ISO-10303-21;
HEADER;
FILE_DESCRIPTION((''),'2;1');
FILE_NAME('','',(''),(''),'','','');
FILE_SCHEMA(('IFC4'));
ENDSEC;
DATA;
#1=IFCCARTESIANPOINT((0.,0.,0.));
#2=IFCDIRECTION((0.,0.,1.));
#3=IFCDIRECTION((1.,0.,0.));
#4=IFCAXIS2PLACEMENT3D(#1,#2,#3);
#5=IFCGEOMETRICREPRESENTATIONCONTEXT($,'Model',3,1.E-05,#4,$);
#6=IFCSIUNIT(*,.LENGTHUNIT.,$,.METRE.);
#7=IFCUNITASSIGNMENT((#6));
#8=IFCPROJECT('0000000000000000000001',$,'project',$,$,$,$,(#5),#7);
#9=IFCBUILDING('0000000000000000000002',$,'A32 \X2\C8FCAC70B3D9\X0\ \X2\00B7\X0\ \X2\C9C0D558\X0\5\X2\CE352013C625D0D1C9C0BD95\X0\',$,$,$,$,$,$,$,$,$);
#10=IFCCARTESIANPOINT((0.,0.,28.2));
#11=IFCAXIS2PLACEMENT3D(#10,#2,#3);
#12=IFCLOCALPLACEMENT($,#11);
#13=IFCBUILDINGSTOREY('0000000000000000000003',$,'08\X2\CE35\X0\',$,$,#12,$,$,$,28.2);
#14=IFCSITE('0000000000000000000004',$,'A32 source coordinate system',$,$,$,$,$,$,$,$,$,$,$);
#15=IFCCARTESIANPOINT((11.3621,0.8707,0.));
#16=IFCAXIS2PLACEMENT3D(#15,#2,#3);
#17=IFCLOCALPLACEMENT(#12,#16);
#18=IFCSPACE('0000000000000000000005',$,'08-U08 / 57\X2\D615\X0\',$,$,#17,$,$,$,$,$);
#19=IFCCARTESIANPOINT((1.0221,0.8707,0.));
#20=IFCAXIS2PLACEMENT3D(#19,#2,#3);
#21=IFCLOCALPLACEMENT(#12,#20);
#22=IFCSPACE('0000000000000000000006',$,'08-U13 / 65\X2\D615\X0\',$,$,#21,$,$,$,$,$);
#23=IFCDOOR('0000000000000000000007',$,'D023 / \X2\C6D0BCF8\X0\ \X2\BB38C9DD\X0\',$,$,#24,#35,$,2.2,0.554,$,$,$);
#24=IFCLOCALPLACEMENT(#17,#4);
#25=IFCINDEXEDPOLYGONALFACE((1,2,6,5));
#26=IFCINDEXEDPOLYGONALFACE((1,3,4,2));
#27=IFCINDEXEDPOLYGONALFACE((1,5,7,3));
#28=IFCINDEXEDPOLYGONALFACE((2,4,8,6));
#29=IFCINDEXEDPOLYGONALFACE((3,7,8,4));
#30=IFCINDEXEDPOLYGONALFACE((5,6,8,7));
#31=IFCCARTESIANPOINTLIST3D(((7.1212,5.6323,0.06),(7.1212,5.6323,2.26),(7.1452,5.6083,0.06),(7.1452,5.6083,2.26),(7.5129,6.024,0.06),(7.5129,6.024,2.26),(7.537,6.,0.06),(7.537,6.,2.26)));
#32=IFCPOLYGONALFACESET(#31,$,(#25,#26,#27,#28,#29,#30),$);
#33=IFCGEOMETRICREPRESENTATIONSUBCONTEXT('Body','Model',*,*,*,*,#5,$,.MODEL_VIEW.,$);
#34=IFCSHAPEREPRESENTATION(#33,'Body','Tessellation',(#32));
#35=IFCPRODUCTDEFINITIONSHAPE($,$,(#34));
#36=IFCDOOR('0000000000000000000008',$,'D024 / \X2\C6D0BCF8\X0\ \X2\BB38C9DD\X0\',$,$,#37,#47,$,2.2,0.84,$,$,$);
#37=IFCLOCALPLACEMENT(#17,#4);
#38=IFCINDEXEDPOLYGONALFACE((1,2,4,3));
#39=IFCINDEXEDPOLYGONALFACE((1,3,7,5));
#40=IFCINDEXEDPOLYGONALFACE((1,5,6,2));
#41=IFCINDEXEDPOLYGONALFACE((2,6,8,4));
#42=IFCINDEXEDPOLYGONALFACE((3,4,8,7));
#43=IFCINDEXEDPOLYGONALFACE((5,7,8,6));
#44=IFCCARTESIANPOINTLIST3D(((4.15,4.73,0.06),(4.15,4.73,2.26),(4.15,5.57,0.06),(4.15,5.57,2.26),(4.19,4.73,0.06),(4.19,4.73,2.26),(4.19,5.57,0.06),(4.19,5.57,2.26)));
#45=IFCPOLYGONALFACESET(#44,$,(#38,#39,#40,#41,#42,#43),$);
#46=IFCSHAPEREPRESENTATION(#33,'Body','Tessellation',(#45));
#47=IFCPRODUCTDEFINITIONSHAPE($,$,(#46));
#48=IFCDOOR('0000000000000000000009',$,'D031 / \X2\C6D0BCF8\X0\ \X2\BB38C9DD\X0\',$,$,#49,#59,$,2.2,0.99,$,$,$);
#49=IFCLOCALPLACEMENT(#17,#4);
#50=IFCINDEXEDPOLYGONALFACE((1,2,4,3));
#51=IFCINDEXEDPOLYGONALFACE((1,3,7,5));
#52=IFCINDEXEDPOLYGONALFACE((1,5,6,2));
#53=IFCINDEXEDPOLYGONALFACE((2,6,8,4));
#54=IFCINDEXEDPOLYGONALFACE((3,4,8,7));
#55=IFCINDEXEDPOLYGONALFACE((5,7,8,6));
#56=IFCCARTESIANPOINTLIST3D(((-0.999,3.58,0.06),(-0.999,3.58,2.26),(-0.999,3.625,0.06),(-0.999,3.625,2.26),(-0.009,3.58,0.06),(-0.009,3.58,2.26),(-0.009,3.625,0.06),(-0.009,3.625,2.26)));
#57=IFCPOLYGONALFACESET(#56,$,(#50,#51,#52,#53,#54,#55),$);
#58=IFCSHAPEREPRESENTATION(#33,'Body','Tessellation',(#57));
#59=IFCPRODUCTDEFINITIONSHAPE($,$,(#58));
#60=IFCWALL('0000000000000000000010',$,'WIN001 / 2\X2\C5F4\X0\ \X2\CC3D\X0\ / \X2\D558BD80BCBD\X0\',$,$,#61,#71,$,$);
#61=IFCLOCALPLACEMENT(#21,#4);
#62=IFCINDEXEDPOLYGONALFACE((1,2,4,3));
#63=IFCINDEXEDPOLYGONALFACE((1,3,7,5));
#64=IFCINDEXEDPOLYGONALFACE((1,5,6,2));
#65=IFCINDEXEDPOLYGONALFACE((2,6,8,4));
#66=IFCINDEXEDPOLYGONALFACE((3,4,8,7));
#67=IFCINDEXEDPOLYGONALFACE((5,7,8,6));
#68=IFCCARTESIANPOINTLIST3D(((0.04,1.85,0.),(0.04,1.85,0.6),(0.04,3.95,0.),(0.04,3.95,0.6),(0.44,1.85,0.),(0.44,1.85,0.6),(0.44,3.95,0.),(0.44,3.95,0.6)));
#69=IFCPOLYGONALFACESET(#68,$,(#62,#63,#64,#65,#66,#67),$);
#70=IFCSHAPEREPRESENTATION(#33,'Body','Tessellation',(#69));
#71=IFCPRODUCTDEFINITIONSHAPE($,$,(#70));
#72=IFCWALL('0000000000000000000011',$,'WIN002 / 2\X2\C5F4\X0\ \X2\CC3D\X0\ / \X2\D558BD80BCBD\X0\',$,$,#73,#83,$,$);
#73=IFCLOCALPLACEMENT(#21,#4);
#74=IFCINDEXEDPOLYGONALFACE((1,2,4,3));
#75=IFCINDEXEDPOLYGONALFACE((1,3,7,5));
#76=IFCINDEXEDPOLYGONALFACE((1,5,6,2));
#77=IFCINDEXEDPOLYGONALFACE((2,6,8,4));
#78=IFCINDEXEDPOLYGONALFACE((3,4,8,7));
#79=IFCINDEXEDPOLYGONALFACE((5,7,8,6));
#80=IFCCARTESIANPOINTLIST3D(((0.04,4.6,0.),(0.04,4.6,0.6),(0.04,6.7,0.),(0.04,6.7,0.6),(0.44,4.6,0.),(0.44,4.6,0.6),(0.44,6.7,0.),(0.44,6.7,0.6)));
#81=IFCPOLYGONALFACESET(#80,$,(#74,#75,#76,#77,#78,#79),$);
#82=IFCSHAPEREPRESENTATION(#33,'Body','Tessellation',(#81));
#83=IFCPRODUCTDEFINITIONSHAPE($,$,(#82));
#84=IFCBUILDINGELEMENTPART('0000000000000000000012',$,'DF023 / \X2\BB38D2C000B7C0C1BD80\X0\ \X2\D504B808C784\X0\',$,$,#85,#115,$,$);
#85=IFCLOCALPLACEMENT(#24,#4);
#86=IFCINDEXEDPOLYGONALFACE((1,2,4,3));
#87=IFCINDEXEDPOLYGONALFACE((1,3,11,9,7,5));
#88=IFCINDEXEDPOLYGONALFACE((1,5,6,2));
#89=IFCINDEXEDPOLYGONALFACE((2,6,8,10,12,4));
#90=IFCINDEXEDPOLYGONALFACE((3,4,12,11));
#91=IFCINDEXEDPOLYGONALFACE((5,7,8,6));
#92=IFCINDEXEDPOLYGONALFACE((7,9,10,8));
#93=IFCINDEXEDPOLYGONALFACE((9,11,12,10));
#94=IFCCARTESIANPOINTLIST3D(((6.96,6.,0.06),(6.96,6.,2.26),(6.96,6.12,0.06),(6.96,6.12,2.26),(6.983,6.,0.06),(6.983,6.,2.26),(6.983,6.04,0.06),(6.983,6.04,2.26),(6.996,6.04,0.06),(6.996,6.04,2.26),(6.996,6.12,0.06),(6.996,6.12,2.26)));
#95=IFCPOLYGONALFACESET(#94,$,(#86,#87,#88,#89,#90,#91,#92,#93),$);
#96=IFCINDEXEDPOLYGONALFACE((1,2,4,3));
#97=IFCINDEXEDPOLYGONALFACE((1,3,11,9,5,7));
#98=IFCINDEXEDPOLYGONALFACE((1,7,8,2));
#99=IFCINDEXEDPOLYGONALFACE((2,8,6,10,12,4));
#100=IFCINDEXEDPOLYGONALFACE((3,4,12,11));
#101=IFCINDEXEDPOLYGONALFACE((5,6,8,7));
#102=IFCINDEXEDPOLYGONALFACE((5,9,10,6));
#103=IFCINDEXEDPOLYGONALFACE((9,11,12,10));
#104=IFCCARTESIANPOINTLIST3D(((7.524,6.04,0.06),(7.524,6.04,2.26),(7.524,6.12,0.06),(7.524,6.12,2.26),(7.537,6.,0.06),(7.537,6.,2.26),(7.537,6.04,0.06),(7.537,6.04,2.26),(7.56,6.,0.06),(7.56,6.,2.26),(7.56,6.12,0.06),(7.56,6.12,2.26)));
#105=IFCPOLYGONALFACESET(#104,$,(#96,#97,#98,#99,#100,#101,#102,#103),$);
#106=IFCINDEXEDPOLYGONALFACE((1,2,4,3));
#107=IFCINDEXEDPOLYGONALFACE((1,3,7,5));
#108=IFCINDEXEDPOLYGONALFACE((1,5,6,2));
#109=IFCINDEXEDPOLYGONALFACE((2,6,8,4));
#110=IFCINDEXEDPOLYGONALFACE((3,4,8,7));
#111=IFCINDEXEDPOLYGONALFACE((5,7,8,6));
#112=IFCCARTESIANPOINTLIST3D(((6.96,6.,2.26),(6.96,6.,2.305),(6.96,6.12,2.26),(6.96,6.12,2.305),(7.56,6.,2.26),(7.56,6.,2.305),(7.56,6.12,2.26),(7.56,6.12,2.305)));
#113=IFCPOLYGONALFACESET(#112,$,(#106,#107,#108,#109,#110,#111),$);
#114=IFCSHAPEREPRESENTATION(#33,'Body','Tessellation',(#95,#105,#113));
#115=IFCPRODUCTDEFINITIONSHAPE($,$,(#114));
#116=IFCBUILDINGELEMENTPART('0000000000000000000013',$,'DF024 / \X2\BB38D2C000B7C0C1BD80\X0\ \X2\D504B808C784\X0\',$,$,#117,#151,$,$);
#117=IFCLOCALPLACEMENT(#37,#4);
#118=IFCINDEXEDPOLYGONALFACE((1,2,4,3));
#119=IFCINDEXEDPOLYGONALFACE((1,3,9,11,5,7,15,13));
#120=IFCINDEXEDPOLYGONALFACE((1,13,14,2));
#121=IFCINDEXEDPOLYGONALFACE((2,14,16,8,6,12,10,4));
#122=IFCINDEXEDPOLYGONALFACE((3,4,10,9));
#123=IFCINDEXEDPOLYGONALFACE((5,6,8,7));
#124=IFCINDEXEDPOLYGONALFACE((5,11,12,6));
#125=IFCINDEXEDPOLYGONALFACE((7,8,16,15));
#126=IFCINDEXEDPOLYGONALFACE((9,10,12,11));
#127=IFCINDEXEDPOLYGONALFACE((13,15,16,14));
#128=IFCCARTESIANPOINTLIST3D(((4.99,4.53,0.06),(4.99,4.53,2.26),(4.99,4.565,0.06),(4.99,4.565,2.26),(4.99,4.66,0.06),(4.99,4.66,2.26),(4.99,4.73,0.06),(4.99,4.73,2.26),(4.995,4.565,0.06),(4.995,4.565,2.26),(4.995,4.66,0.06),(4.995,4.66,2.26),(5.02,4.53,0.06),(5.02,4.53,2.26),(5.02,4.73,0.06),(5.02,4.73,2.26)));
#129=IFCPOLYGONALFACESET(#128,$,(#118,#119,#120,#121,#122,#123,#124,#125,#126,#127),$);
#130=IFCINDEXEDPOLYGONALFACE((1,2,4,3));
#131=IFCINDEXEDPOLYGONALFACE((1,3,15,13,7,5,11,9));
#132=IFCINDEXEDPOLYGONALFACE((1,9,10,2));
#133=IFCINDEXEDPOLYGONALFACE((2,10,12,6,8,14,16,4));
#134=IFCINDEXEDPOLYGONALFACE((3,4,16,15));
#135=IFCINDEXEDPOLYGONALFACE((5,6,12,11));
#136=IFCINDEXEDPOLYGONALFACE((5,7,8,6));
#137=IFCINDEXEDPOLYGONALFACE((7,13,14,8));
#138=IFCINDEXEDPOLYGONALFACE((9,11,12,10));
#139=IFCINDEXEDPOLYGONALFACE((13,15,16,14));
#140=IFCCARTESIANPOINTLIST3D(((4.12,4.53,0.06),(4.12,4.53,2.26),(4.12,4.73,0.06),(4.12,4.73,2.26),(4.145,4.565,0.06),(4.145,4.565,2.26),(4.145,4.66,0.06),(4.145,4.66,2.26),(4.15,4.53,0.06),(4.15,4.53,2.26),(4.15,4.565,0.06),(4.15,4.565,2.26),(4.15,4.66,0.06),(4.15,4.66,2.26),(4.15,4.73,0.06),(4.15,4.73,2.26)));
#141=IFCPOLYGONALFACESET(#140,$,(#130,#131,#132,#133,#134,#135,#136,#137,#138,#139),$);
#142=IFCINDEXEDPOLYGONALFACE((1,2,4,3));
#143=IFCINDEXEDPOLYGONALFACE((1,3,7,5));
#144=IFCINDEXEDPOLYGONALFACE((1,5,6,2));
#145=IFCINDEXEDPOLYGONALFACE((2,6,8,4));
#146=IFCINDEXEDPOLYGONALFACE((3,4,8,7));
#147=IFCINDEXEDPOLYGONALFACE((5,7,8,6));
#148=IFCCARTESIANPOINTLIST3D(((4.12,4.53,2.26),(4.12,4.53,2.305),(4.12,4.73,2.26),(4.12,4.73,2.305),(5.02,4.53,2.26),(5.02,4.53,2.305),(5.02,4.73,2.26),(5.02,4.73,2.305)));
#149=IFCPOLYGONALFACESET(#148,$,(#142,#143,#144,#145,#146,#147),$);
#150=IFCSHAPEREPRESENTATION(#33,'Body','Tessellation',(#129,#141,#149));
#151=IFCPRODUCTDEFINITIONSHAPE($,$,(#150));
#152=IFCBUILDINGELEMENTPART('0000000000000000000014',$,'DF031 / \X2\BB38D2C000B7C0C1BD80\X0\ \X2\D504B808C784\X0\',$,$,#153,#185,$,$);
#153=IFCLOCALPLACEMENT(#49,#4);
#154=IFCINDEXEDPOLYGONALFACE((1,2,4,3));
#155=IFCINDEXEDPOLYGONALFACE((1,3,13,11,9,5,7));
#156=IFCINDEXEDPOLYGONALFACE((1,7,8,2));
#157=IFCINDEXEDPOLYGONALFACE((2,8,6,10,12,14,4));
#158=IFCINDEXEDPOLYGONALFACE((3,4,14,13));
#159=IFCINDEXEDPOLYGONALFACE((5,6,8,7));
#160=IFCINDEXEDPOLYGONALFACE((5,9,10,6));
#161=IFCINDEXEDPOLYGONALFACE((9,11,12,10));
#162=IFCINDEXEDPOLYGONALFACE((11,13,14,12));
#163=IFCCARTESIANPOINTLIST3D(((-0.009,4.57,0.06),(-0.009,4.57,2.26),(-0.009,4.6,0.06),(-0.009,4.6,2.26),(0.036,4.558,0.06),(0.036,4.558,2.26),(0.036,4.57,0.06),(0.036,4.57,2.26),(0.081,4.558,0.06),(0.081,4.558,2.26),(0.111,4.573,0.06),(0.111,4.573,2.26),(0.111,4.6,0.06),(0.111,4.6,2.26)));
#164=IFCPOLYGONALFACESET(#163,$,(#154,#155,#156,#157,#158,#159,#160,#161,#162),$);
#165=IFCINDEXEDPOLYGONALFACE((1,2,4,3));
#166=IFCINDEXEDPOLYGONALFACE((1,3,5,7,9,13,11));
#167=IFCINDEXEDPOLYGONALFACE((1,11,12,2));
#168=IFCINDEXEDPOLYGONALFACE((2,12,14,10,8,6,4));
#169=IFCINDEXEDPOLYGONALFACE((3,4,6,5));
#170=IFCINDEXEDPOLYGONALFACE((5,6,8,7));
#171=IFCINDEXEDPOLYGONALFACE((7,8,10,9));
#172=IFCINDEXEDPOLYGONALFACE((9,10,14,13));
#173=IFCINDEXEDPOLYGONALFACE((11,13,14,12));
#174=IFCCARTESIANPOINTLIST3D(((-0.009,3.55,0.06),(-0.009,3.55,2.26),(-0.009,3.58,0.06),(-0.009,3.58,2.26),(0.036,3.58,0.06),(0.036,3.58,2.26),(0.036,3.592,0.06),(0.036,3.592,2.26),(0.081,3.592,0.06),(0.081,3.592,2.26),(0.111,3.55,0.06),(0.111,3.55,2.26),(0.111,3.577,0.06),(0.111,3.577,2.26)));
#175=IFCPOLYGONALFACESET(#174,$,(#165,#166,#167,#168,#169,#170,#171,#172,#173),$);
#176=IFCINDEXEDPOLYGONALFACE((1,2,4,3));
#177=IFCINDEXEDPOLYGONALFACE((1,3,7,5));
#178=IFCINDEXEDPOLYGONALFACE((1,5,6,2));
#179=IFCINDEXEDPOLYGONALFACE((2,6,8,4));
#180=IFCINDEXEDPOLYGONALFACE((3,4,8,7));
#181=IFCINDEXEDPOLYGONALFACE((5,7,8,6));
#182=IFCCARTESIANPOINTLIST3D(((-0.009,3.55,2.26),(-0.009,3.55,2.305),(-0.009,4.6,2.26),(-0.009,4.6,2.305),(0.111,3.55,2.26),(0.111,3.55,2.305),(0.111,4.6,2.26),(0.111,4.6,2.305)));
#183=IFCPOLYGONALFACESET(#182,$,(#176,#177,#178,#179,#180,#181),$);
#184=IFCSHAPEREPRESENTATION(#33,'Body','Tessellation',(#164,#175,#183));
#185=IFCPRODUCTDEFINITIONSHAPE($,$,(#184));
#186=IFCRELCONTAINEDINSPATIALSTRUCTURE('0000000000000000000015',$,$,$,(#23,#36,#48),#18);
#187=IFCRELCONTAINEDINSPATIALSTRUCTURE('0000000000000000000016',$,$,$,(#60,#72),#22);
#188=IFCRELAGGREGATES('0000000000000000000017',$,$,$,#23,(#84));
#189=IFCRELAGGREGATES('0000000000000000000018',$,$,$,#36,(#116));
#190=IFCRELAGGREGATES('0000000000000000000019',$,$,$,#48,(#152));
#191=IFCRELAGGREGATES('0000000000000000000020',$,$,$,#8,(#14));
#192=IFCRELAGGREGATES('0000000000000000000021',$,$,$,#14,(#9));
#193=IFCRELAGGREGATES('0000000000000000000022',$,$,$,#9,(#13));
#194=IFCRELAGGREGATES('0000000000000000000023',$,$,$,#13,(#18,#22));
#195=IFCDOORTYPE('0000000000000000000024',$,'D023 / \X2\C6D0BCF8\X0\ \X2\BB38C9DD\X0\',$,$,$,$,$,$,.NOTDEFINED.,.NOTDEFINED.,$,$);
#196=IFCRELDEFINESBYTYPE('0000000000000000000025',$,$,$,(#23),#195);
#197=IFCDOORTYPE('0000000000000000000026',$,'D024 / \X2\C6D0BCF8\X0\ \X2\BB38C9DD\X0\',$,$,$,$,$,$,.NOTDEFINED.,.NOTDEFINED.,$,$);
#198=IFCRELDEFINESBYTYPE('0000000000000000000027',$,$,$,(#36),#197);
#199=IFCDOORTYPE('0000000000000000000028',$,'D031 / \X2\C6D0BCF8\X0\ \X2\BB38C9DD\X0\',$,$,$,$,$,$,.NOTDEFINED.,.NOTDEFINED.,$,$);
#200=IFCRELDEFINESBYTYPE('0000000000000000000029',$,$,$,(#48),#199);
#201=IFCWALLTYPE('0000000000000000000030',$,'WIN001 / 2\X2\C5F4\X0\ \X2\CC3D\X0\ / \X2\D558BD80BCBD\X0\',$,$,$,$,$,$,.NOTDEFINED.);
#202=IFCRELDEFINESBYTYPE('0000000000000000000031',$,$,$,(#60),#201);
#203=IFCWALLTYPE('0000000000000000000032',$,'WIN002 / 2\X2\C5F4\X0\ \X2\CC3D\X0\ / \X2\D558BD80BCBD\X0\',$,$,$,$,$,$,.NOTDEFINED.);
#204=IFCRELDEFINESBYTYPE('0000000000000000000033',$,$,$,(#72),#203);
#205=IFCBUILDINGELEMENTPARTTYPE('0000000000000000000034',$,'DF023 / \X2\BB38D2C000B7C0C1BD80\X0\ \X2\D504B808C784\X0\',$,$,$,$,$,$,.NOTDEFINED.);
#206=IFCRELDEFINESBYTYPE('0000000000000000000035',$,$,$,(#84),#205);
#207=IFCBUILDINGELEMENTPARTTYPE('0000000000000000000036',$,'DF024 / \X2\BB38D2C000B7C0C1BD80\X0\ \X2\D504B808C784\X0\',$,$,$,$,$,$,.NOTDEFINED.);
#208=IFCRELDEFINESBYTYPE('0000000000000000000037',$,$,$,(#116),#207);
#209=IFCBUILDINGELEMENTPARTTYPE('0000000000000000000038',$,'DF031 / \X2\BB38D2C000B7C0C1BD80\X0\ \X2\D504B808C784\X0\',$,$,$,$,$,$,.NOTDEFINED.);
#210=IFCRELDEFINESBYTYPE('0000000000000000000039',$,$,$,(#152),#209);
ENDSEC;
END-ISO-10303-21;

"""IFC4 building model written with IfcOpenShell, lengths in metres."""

from ifc_helpers import new_model, si_unit, frame, origin, origin_with_axes, place, context, subcontext, project, spatial, polyline, outline, extrude, source, transform, mapped, type_object, type_shapes, element, aggregate, save


model = new_model("IFC4")

# Units and contexts
model_context = context("Model", 3, precision=1e-05, world=origin_with_axes())
body_context = subcontext(model_context, "Body", "Model", "MODEL_VIEW")
ifc_project = project(units=[si_unit("LENGTHUNIT", "METRE")], contexts=[model_context])

# Site, building, storey, space
site = spatial("IfcSite", under=ifc_project, Name="A32 source coordinate system")
building = spatial("IfcBuilding", under=site, Name="A32 주거동 · 지하5층–옥탑지붕")
storey_placement = place(None, frame((0.0, 0.0, 28.2), z_axis=(0.0, 0.0, 1.0), x_axis=(1.0, 0.0, 0.0)))
storey = spatial("IfcBuildingStorey", under=building, at=storey_placement, Name="08층", Elevation=28.2)
space_1_placement = place(storey_placement, frame((11.3621, 0.8707, 0.0), z_axis=(0.0, 0.0, 1.0), x_axis=(1.0, 0.0, 0.0)))
space_1 = spatial("IfcSpace", under=storey, at=space_1_placement, Name="08-U08 / 57형")

# Doors
door_type_1 = type_object("IfcDoorType", Name="D023 / 원본 문짝", OperationType="NOTDEFINED", PredefinedType="NOTDEFINED")
shared_shape_1 = source(origin(), body_context, "Body", "SweptSolid", [
    extrude(outline(polyline([(7.537, 6.0), (7.1452, 5.6083), (7.1212, 5.6323), (7.5129, 6.024), (7.537, 6.0)])), frame((0.0, 0.0, 0.06)), (0.0, 0.0, 1.0), 2.2),
])
type_shapes(door_type_1, [shared_shape_1])
door_1_placement = place(space_1_placement, origin_with_axes())
door_1 = element("IfcDoor", 1, at=door_1_placement, inside=space_1, type_object=door_type_1, Name="D023 / 원본 문짝", OverallHeight=2.2, OverallWidth=0.554, context=body_context, shape_type="MappedRepresentation", body=[
    mapped(shared_shape_1, transform((0.0, 0.0, 0.0), scale=1.0)),
])
door_type_2 = type_object("IfcDoorType", Name="D024 / 원본 문짝", OperationType="NOTDEFINED", PredefinedType="NOTDEFINED")
shared_shape_2 = source(origin(), body_context, "Body", "SweptSolid", [
    extrude(outline(polyline([(4.15, 4.73), (4.15, 5.57), (4.19, 5.57), (4.19, 4.73), (4.15, 4.73)])), frame((0.0, 0.0, 0.06)), (0.0, 0.0, 1.0), 2.2),
])
type_shapes(door_type_2, [shared_shape_2])
door_2_placement = place(space_1_placement, origin_with_axes())
door_2 = element("IfcDoor", 2, at=door_2_placement, inside=space_1, type_object=door_type_2, Name="D024 / 원본 문짝", OverallHeight=2.2, OverallWidth=0.84, context=body_context, shape_type="MappedRepresentation", body=[
    mapped(shared_shape_2, transform((0.0, 0.0, 0.0), scale=1.0)),
])
door_type_3 = type_object("IfcDoorType", Name="D031 / 원본 문짝", OperationType="NOTDEFINED", PredefinedType="NOTDEFINED")
shared_shape_3 = source(origin(), body_context, "Body", "SweptSolid", [
    extrude(outline(polyline([(-0.009, 3.58), (-0.999, 3.58), (-0.999, 3.625), (-0.009, 3.625), (-0.009, 3.58)])), frame((0.0, 0.0, 0.06)), (0.0, 0.0, 1.0), 2.2),
])
type_shapes(door_type_3, [shared_shape_3])
door_3_placement = place(space_1_placement, origin_with_axes())
door_3 = element("IfcDoor", 3, at=door_3_placement, inside=space_1, type_object=door_type_3, Name="D031 / 원본 문짝", OverallHeight=2.2, OverallWidth=0.99, context=body_context, shape_type="MappedRepresentation", body=[
    mapped(shared_shape_3, transform((0.0, 0.0, 0.0), scale=1.0)),
])

# Shared definitions
space_2_placement = place(storey_placement, frame((1.0221, 0.8707, 0.0), z_axis=(0.0, 0.0, 1.0), x_axis=(1.0, 0.0, 0.0)))
space_2 = spatial("IfcSpace", under=storey, at=space_2_placement, Name="08-U13 / 65형")

# Walls
wall_type_1 = type_object("IfcWallType", Name="WIN001 / 2열 창 / 하부벽", PredefinedType="NOTDEFINED")
shared_shape_4 = source(origin(), body_context, "Body", "SweptSolid", [
    extrude(outline(polyline([(0.04, 3.95), (0.44, 3.95), (0.44, 1.85), (0.04, 1.85), (0.04, 3.95)])), origin(), (0.0, 0.0, 1.0), 0.6),
])
type_shapes(wall_type_1, [shared_shape_4])
wall_1_placement = place(space_2_placement, origin_with_axes())
element("IfcWall", 4, at=wall_1_placement, inside=space_2, type_object=wall_type_1, Name="WIN001 / 2열 창 / 하부벽", context=body_context, shape_type="MappedRepresentation", body=[
    mapped(shared_shape_4, transform((0.0, 0.0, 0.0), scale=1.0)),
])
wall_type_2 = type_object("IfcWallType", Name="WIN002 / 2열 창 / 하부벽", PredefinedType="NOTDEFINED")
shared_shape_5 = source(origin(), body_context, "Body", "SweptSolid", [
    extrude(outline(polyline([(0.04, 6.7), (0.44, 6.7), (0.44, 4.6), (0.04, 4.6), (0.04, 6.7)])), origin(), (0.0, 0.0, 1.0), 0.6),
])
type_shapes(wall_type_2, [shared_shape_5])
wall_2_placement = place(space_2_placement, origin_with_axes())
element("IfcWall", 5, at=wall_2_placement, inside=space_2, type_object=wall_type_2, Name="WIN002 / 2열 창 / 하부벽", context=body_context, shape_type="MappedRepresentation", body=[
    mapped(shared_shape_5, transform((0.0, 0.0, 0.0), scale=1.0)),
])

# Building element parts
building_element_part_type_1 = type_object("IfcBuildingElementPartType", Name="DF023 / 문틀·상부 프레임", PredefinedType="NOTDEFINED")
shared_shape_6 = source(origin(), body_context, "Body", "SweptSolid", [
    extrude(outline(polyline([(6.996, 6.12), (6.996, 6.04), (6.983, 6.04), (6.983, 6.0), (6.96, 6.0), (6.96, 6.12), (6.996, 6.12)])), frame((0.0, 0.0, 0.06)), (0.0, 0.0, 1.0), 2.2),
    extrude(outline(polyline([(7.56, 6.0), (7.537, 6.0), (7.537, 6.04), (7.524, 6.04), (7.524, 6.12), (7.56, 6.12), (7.56, 6.0)])), frame((0.0, 0.0, 0.06)), (0.0, 0.0, 1.0), 2.2),
    extrude(outline(polyline([(6.96, 6.0), (6.96, 6.12), (7.56, 6.12), (7.56, 6.0), (6.96, 6.0)])), frame((0.0, 0.0, 2.26)), (0.0, 0.0, 1.0), 0.045),
])
type_shapes(building_element_part_type_1, [shared_shape_6])
building_element_part_1_placement = place(door_1_placement, origin_with_axes())
building_element_part_1 = element("IfcBuildingElementPart", 6, at=building_element_part_1_placement, type_object=building_element_part_type_1, Name="DF023 / 문틀·상부 프레임", context=body_context, shape_type="MappedRepresentation", body=[
    mapped(shared_shape_6, transform((0.0, 0.0, 0.0), scale=1.0)),
])
aggregate(door_1, [building_element_part_1])
building_element_part_type_2 = type_object("IfcBuildingElementPartType", Name="DF024 / 문틀·상부 프레임", PredefinedType="NOTDEFINED")
shared_shape_7 = source(origin(), body_context, "Body", "SweptSolid", [
    extrude(outline(polyline([(5.02, 4.53), (4.99, 4.53), (4.99, 4.565), (4.995, 4.565), (4.995, 4.66), (4.99, 4.66), (4.99, 4.73), (5.02, 4.73), (5.02, 4.53)])), frame((0.0, 0.0, 0.06)), (0.0, 0.0, 1.0), 2.2),
    extrude(outline(polyline([(4.15, 4.73), (4.15, 4.66), (4.145, 4.66), (4.145, 4.565), (4.15, 4.565), (4.15, 4.53), (4.12, 4.53), (4.12, 4.73), (4.15, 4.73)])), frame((0.0, 0.0, 0.06)), (0.0, 0.0, 1.0), 2.2),
    extrude(outline(polyline([(4.12, 4.53), (4.12, 4.73), (5.02, 4.73), (5.02, 4.53), (4.12, 4.53)])), frame((0.0, 0.0, 2.26)), (0.0, 0.0, 1.0), 0.045),
])
type_shapes(building_element_part_type_2, [shared_shape_7])
building_element_part_2_placement = place(door_2_placement, origin_with_axes())
building_element_part_2 = element("IfcBuildingElementPart", 7, at=building_element_part_2_placement, type_object=building_element_part_type_2, Name="DF024 / 문틀·상부 프레임", context=body_context, shape_type="MappedRepresentation", body=[
    mapped(shared_shape_7, transform((0.0, 0.0, 0.0), scale=1.0)),
])
aggregate(door_2, [building_element_part_2])
building_element_part_type_3 = type_object("IfcBuildingElementPartType", Name="DF031 / 문틀·상부 프레임", PredefinedType="NOTDEFINED")
shared_shape_8 = source(origin(), body_context, "Body", "SweptSolid", [
    extrude(outline(polyline([(0.111, 4.6), (0.111, 4.573), (0.081, 4.558), (0.036, 4.558), (0.036, 4.57), (-0.009, 4.57), (-0.009, 4.6), (0.111, 4.6)])), frame((0.0, 0.0, 0.06)), (0.0, 0.0, 1.0), 2.2),
    extrude(outline(polyline([(-0.009, 3.58), (0.036, 3.58), (0.036, 3.592), (0.081, 3.592), (0.111, 3.577), (0.111, 3.55), (-0.009, 3.55), (-0.009, 3.58)])), frame((0.0, 0.0, 0.06)), (0.0, 0.0, 1.0), 2.2),
    extrude(outline(polyline([(-0.009, 3.55), (-0.009, 4.6), (0.111, 4.6), (0.111, 3.55), (-0.009, 3.55)])), frame((0.0, 0.0, 2.26)), (0.0, 0.0, 1.0), 0.045),
])
type_shapes(building_element_part_type_3, [shared_shape_8])
building_element_part_3_placement = place(door_3_placement, origin_with_axes())
building_element_part_3 = element("IfcBuildingElementPart", 8, at=building_element_part_3_placement, type_object=building_element_part_type_3, Name="DF031 / 문틀·상부 프레임", context=body_context, shape_type="MappedRepresentation", body=[
    mapped(shared_shape_8, transform((0.0, 0.0, 0.0), scale=1.0)),
])
aggregate(door_3, [building_element_part_3])

save(model, "model.ifc")
